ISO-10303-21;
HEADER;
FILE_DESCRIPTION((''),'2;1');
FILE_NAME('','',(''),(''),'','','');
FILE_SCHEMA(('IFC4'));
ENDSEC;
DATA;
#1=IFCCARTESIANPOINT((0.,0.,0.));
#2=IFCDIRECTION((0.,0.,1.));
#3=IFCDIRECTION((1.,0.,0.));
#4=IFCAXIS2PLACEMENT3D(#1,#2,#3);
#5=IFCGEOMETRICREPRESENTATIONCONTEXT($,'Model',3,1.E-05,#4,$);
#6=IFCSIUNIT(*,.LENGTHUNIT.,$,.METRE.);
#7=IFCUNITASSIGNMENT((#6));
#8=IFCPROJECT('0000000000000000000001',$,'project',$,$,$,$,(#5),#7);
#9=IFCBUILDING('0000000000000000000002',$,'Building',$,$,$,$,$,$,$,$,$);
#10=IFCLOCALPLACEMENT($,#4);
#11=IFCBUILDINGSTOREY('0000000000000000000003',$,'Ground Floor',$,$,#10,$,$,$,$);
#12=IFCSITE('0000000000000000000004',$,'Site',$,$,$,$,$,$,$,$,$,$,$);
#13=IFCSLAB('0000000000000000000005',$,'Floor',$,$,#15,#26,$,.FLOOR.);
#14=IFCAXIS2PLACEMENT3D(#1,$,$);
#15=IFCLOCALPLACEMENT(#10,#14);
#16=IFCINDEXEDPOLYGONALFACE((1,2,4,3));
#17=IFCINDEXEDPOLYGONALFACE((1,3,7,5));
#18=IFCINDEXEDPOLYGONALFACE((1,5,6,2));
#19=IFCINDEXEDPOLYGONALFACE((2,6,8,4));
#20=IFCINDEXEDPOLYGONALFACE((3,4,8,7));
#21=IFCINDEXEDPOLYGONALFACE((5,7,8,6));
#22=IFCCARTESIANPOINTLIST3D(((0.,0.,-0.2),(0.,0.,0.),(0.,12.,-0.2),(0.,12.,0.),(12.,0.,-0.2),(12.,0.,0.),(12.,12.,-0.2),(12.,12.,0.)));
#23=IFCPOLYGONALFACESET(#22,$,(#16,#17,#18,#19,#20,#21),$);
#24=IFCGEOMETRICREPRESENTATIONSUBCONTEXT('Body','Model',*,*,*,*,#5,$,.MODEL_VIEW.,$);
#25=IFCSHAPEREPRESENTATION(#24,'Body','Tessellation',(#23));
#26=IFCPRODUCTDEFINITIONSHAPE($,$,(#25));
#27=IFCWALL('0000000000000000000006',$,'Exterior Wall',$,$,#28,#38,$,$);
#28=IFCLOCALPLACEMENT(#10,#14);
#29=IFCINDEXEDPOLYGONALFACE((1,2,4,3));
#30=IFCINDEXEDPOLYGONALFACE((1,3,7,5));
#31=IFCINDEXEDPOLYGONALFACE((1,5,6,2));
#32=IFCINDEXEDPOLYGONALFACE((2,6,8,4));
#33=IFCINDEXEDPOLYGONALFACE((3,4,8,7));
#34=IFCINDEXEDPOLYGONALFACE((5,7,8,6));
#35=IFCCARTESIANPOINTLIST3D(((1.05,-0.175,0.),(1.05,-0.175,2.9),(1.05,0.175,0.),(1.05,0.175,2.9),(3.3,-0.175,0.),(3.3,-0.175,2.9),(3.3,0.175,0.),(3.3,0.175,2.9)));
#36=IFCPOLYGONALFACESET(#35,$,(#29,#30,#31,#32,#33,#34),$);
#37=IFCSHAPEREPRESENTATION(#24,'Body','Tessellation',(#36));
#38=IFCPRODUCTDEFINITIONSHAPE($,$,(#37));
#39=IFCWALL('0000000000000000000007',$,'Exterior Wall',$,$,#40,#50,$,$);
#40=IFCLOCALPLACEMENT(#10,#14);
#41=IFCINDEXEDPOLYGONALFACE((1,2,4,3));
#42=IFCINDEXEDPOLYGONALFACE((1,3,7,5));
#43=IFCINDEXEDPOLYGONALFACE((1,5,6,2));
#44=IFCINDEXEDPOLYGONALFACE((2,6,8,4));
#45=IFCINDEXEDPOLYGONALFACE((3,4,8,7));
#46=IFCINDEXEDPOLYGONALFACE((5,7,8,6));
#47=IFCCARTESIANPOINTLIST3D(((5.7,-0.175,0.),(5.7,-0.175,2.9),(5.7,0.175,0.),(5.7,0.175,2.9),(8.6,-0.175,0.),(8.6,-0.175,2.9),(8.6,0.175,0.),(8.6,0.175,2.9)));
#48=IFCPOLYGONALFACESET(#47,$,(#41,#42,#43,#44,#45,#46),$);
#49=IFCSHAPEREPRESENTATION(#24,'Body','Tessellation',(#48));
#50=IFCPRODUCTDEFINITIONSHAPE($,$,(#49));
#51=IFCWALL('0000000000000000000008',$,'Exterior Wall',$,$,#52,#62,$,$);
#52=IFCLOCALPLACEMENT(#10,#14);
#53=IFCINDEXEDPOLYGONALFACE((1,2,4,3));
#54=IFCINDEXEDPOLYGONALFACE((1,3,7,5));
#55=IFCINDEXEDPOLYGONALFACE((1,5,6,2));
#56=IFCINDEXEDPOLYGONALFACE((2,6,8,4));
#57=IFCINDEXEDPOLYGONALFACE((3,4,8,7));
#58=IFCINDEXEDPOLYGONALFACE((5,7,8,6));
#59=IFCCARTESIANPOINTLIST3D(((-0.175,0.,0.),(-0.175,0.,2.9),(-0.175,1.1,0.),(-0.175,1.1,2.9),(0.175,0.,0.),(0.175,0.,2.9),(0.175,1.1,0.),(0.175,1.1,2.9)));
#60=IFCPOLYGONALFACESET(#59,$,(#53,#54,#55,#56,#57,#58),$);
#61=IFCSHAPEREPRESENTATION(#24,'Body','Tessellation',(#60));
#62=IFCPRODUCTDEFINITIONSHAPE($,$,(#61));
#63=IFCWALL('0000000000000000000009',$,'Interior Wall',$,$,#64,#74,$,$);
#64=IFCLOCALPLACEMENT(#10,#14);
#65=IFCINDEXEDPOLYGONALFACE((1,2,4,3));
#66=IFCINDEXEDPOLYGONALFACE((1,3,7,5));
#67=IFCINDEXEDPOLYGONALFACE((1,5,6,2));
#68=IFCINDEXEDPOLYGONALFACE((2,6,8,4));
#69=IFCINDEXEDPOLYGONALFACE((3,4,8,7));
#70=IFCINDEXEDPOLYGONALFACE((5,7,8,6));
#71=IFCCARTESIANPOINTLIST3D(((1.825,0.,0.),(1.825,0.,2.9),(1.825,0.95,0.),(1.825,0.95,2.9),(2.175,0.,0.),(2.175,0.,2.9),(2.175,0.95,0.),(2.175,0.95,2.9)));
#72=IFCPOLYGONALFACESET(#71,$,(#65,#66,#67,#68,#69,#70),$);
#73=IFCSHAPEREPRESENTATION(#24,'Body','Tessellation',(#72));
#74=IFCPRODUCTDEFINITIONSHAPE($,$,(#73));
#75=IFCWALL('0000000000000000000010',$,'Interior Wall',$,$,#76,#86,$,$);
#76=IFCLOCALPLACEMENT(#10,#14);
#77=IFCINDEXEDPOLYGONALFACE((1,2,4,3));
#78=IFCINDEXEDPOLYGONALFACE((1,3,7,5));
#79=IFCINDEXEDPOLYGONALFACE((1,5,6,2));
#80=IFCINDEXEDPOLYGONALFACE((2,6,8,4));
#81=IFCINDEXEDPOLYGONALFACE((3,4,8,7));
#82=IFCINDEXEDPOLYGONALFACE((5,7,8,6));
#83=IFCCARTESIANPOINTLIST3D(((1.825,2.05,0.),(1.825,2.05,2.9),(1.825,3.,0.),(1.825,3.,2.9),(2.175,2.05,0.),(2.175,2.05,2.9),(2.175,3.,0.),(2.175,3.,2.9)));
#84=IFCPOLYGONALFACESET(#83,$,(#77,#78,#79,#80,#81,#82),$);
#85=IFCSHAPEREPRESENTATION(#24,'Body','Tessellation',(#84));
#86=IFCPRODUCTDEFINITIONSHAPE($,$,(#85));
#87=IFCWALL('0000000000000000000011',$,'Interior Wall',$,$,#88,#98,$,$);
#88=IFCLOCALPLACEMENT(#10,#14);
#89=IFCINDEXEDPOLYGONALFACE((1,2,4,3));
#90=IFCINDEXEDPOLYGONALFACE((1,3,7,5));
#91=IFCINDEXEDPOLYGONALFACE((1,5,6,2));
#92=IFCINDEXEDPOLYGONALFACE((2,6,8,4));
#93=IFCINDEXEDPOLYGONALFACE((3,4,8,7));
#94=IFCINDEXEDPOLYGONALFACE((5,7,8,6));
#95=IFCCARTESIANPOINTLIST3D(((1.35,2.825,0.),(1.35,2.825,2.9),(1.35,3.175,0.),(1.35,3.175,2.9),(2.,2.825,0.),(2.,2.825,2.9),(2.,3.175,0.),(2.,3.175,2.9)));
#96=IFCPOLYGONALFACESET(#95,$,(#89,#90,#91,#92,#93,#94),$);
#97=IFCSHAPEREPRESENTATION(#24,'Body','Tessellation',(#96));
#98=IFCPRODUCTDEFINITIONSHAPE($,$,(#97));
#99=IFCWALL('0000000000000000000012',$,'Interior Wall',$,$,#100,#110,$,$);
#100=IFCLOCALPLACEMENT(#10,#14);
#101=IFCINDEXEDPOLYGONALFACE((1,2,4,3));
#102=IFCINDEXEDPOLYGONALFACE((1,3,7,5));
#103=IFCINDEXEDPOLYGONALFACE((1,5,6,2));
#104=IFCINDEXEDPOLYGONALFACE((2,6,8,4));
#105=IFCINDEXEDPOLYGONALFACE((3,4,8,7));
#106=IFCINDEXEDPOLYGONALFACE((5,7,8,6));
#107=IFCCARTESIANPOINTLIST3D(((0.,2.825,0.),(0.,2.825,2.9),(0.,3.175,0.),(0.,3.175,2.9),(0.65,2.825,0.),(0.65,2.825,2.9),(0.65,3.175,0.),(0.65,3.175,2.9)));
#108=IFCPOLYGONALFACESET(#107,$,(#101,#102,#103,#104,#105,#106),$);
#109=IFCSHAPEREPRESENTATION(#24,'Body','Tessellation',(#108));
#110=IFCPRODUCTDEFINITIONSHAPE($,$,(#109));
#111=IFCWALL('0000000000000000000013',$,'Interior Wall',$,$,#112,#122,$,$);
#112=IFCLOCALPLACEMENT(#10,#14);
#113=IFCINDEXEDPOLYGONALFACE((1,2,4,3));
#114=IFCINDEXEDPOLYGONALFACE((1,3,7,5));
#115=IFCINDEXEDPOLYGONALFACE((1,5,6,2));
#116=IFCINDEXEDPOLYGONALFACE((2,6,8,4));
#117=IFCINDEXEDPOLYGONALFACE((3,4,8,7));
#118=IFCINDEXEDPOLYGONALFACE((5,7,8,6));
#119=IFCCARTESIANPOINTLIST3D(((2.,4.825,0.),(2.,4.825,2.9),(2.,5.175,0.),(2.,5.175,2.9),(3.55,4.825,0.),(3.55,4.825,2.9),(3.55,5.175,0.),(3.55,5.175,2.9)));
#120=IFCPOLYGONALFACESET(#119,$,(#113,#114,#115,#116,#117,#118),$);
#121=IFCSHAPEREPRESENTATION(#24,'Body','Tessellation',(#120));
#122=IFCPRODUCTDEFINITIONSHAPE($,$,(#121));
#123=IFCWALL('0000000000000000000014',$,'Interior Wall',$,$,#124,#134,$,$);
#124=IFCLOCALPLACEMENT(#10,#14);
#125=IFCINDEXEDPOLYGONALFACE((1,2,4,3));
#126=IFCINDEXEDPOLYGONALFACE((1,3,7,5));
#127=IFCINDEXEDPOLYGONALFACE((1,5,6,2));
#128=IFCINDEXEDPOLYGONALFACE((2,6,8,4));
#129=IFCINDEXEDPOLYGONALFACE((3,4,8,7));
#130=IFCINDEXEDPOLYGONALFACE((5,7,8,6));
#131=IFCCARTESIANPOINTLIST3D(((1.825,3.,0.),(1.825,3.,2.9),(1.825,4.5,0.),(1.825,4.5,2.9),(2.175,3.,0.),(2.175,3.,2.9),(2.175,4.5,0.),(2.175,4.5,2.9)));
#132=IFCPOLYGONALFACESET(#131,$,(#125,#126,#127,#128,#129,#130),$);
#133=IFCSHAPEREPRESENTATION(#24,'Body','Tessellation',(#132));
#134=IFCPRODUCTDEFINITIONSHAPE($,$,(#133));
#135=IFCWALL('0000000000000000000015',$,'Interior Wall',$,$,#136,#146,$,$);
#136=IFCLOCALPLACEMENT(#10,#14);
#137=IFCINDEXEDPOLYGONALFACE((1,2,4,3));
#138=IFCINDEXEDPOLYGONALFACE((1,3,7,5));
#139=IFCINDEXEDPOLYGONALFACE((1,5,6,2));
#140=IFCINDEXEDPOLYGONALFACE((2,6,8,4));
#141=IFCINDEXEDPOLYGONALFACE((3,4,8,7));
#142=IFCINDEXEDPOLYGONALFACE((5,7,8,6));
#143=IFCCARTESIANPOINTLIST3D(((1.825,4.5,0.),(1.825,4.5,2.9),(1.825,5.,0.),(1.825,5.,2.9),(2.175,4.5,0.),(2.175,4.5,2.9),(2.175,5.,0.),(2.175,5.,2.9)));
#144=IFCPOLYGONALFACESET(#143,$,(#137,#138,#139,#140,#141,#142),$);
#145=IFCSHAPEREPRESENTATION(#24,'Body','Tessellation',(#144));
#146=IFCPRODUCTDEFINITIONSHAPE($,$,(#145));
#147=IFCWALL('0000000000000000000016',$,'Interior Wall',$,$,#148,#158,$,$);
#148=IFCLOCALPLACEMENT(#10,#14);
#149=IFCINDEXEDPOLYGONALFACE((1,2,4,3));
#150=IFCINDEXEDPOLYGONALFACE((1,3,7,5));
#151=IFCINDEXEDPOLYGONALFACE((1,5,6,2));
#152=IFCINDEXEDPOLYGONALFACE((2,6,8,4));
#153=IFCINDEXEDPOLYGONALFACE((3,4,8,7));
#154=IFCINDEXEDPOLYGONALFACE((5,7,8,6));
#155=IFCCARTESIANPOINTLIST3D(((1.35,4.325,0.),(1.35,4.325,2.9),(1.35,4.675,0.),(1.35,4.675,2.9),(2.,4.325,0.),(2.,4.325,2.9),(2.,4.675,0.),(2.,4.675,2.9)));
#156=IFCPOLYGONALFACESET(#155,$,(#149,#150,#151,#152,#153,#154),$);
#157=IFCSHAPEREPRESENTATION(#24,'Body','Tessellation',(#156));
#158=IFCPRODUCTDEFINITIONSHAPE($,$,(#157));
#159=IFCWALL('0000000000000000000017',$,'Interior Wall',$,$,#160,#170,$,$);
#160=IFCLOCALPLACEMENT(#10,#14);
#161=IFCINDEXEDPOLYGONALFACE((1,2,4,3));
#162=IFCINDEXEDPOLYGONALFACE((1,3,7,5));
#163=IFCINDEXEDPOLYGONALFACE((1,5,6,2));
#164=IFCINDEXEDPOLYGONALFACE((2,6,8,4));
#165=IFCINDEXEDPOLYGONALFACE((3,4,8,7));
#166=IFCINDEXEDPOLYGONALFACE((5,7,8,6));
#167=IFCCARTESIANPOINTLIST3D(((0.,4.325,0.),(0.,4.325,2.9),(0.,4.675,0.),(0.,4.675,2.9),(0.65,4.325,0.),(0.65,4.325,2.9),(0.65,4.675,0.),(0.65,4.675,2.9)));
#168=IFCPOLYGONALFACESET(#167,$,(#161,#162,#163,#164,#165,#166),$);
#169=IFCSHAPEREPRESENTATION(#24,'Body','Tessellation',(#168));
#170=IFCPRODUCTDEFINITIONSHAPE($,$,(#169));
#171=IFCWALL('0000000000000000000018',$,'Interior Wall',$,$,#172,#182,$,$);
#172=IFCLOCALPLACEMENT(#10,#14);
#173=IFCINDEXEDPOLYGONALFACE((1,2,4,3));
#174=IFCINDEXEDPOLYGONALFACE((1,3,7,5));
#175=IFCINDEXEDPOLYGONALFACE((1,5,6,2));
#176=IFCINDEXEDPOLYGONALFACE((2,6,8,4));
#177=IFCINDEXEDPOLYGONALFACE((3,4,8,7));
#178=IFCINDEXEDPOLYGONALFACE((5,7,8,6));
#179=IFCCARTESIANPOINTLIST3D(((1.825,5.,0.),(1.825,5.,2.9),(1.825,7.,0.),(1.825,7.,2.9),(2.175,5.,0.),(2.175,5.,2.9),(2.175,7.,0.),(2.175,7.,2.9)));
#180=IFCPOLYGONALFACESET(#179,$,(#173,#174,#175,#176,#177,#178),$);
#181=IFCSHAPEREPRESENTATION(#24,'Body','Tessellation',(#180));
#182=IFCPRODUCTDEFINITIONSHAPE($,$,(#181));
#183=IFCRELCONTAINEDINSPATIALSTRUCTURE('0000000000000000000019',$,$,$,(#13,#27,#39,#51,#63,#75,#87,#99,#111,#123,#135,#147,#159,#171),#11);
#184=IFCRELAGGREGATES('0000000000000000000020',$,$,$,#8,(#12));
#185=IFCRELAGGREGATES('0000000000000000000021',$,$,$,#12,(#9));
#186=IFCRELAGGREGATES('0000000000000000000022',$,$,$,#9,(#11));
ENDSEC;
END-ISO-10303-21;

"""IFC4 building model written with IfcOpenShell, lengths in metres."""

from ifc_helpers import new_model, si_unit, frame, origin_with_axes, place, context, subcontext, project, spatial, indexed_curve, outline, extrude, element, save


model = new_model("IFC4")

# Units and contexts
model_context = context("Model", 3, precision=1e-05, world=origin_with_axes())
body_context = subcontext(model_context, "Body", "Model", "MODEL_VIEW")
ifc_project = project(units=[si_unit("LENGTHUNIT", "METRE")], contexts=[model_context])

# Site, building, storey
site = spatial("IfcSite", under=ifc_project, Name="Site")
building = spatial("IfcBuilding", under=site, Name="Building")
storey_placement = place(None, origin_with_axes())
storey = spatial("IfcBuildingStorey", under=building, at=storey_placement, Name="Ground Floor")

# Slab
slab_placement = place(storey_placement, frame((0.0, 0.0, -0.2), z_axis=(0.0, 0.0, 1.0), x_axis=(1.0, 0.0, 0.0)))
element("IfcSlab", 1, at=slab_placement, inside=storey, Name="Floor", PredefinedType="FLOOR", context=body_context, shape_type="SweptSolid", body=[
    extrude(outline(indexed_curve([(0.0, 0.0), (12.0, 0.0), (12.0, 12.0), (0.0, 12.0)])), None, (0.0, 0.0, 1.0), 0.2),
])

# Walls
wall_1_placement = place(storey_placement, frame((1.05, 0.0, 0.0), z_axis=(0.0, 0.0, 1.0), x_axis=(1.0, 0.0, 0.0)))
element("IfcWall", 2, at=wall_1_placement, inside=storey, Name="Exterior Wall", context=body_context, shape_type="SweptSolid", body=[
    extrude(outline(indexed_curve([(0.0, 0.0), (0.0, 0.35), (2.25, 0.35), (2.25, 0.0), (0.0, 0.0)], self_intersect=False)), frame((0.0, -0.175, 0.0), z_axis=(0.0, 0.0, 1.0), x_axis=(1.0, 0.0, 0.0)), (0.0, 0.0, 1.0), 2.9),
])
wall_2_placement = place(storey_placement, frame((5.7, 0.0, 0.0), z_axis=(0.0, 0.0, 1.0), x_axis=(1.0, 0.0, 0.0)))
element("IfcWall", 3, at=wall_2_placement, inside=storey, Name="Exterior Wall", context=body_context, shape_type="SweptSolid", body=[
    extrude(outline(indexed_curve([(0.0, 0.0), (0.0, 0.35), (2.9, 0.35), (2.9, 0.0), (0.0, 0.0)], self_intersect=False)), frame((0.0, -0.175, 0.0), z_axis=(0.0, 0.0, 1.0), x_axis=(1.0, 0.0, 0.0)), (0.0, 0.0, 1.0), 2.9),
])
wall_3_placement = place(storey_placement, frame((0.0, 1.1, 0.0), z_axis=(0.0, 0.0, 1.0), x_axis=(0.0, -1.0, 0.0)))
element("IfcWall", 4, at=wall_3_placement, inside=storey, Name="Exterior Wall", context=body_context, shape_type="SweptSolid", body=[
    extrude(outline(indexed_curve([(0.0, 0.0), (0.0, 0.35), (1.1, 0.35), (1.1, 0.0), (0.0, 0.0)], self_intersect=False)), frame((0.0, -0.175, 0.0), z_axis=(0.0, 0.0, 1.0), x_axis=(1.0, 0.0, 0.0)), (0.0, 0.0, 1.0), 2.9),
])
wall_4_placement = place(storey_placement, frame((2.0, 0.0, 0.0), z_axis=(0.0, 0.0, 1.0), x_axis=(0.0, 1.0, 0.0)))
element("IfcWall", 5, at=wall_4_placement, inside=storey, Name="Interior Wall", context=body_context, shape_type="SweptSolid", body=[
    extrude(outline(indexed_curve([(0.0, 0.0), (0.0, 0.35), (0.95, 0.35), (0.95, 0.0), (0.0, 0.0)], self_intersect=False)), frame((0.0, -0.175, 0.0), z_axis=(0.0, 0.0, 1.0), x_axis=(1.0, 0.0, 0.0)), (0.0, 0.0, 1.0), 2.9),
])
wall_5_placement = place(storey_placement, frame((2.0, 2.05, 0.0), z_axis=(0.0, 0.0, 1.0), x_axis=(0.0, 1.0, 0.0)))
element("IfcWall", 6, at=wall_5_placement, inside=storey, Name="Interior Wall", context=body_context, shape_type="SweptSolid", body=[
    extrude(outline(indexed_curve([(0.0, 0.0), (0.0, 0.35), (0.95, 0.35), (0.95, 0.0), (0.0, 0.0)], self_intersect=False)), frame((0.0, -0.175, 0.0), z_axis=(0.0, 0.0, 1.0), x_axis=(1.0, 0.0, 0.0)), (0.0, 0.0, 1.0), 2.9),
])
for number, where, z_axis, x_axis, name in (
    (7, (2.0, 3.0, 0.0), (0.0, 0.0, 1.0), (-1.0, 0.0, 0.0), "Interior Wall"),
    (8, (0.65, 3.0, 0.0), (0.0, 0.0, 1.0), (-1.0, 0.0, 0.0), "Interior Wall"),
):
    element("IfcWall", number, at=place(storey_placement, frame(where, z_axis=z_axis, x_axis=x_axis)), inside=storey, Name=name, context=body_context, shape_type="SweptSolid", body=[
        extrude(outline(indexed_curve([(0.0, 0.0), (0.0, 0.35), (0.65, 0.35), (0.65, 0.0), (0.0, 0.0)], self_intersect=False)), frame((0.0, -0.175, 0.0), z_axis=(0.0, 0.0, 1.0), x_axis=(1.0, 0.0, 0.0)), (0.0, 0.0, 1.0), 2.9),
    ])
wall_6_placement = place(storey_placement, frame((3.55, 5.0, 0.0), z_axis=(0.0, 0.0, 1.0), x_axis=(-1.0, 0.0, 0.0)))
element("IfcWall", 9, at=wall_6_placement, inside=storey, Name="Interior Wall", context=body_context, shape_type="SweptSolid", body=[
    extrude(outline(indexed_curve([(0.0, 0.0), (0.0, 0.35), (1.55, 0.35), (1.55, 0.0), (0.0, 0.0)], self_intersect=False)), frame((0.0, -0.175, 0.0), z_axis=(0.0, 0.0, 1.0), x_axis=(1.0, 0.0, 0.0)), (0.0, 0.0, 1.0), 2.9),
])
wall_7_placement = place(storey_placement, frame((2.0, 4.5, 0.0), z_axis=(0.0, 0.0, 1.0), x_axis=(0.0, -1.0, 0.0)))
element("IfcWall", 10, at=wall_7_placement, inside=storey, Name="Interior Wall", context=body_context, shape_type="SweptSolid", body=[
    extrude(outline(indexed_curve([(0.0, 0.0), (0.0, 0.35), (1.5, 0.35), (1.5, 0.0), (0.0, 0.0)], self_intersect=False)), frame((0.0, -0.175, 0.0), z_axis=(0.0, 0.0, 1.0), x_axis=(1.0, 0.0, 0.0)), (0.0, 0.0, 1.0), 2.9),
])
wall_8_placement = place(storey_placement, frame((2.0, 5.0, 0.0), z_axis=(0.0, 0.0, 1.0), x_axis=(0.0, -1.0, 0.0)))
element("IfcWall", 11, at=wall_8_placement, inside=storey, Name="Interior Wall", context=body_context, shape_type="SweptSolid", body=[
    extrude(outline(indexed_curve([(0.0, 0.0), (0.0, 0.35), (0.5, 0.35), (0.5, 0.0), (0.0, 0.0)], self_intersect=False)), frame((0.0, -0.175, 0.0), z_axis=(0.0, 0.0, 1.0), x_axis=(1.0, 0.0, 0.0)), (0.0, 0.0, 1.0), 2.9),
])
for number, where, z_axis, x_axis, name in (
    (12, (2.0, 4.5, 0.0), (0.0, 0.0, 1.0), (-1.0, 0.0, 0.0), "Interior Wall"),
    (13, (0.65, 4.5, 0.0), (0.0, 0.0, 1.0), (-1.0, 0.0, 0.0), "Interior Wall"),
):
    element("IfcWall", number, at=place(storey_placement, frame(where, z_axis=z_axis, x_axis=x_axis)), inside=storey, Name=name, context=body_context, shape_type="SweptSolid", body=[
        extrude(outline(indexed_curve([(0.0, 0.0), (0.0, 0.35), (0.65, 0.35), (0.65, 0.0), (0.0, 0.0)], self_intersect=False)), frame((0.0, -0.175, 0.0), z_axis=(0.0, 0.0, 1.0), x_axis=(1.0, 0.0, 0.0)), (0.0, 0.0, 1.0), 2.9),
    ])
wall_9_placement = place(storey_placement, frame((2.0, 5.0, 0.0), z_axis=(0.0, 0.0, 1.0), x_axis=(0.0, 1.0, 0.0)))
element("IfcWall", 14, at=wall_9_placement, inside=storey, Name="Interior Wall", context=body_context, shape_type="SweptSolid", body=[
    extrude(outline(indexed_curve([(0.0, 0.0), (0.0, 0.35), (2.0, 0.35), (2.0, 0.0), (0.0, 0.0)], self_intersect=False)), frame((0.0, -0.175, 0.0), z_axis=(0.0, 0.0, 1.0), x_axis=(1.0, 0.0, 0.0)), (0.0, 0.0, 1.0), 2.9),
])

save(model, "model.ifc")
